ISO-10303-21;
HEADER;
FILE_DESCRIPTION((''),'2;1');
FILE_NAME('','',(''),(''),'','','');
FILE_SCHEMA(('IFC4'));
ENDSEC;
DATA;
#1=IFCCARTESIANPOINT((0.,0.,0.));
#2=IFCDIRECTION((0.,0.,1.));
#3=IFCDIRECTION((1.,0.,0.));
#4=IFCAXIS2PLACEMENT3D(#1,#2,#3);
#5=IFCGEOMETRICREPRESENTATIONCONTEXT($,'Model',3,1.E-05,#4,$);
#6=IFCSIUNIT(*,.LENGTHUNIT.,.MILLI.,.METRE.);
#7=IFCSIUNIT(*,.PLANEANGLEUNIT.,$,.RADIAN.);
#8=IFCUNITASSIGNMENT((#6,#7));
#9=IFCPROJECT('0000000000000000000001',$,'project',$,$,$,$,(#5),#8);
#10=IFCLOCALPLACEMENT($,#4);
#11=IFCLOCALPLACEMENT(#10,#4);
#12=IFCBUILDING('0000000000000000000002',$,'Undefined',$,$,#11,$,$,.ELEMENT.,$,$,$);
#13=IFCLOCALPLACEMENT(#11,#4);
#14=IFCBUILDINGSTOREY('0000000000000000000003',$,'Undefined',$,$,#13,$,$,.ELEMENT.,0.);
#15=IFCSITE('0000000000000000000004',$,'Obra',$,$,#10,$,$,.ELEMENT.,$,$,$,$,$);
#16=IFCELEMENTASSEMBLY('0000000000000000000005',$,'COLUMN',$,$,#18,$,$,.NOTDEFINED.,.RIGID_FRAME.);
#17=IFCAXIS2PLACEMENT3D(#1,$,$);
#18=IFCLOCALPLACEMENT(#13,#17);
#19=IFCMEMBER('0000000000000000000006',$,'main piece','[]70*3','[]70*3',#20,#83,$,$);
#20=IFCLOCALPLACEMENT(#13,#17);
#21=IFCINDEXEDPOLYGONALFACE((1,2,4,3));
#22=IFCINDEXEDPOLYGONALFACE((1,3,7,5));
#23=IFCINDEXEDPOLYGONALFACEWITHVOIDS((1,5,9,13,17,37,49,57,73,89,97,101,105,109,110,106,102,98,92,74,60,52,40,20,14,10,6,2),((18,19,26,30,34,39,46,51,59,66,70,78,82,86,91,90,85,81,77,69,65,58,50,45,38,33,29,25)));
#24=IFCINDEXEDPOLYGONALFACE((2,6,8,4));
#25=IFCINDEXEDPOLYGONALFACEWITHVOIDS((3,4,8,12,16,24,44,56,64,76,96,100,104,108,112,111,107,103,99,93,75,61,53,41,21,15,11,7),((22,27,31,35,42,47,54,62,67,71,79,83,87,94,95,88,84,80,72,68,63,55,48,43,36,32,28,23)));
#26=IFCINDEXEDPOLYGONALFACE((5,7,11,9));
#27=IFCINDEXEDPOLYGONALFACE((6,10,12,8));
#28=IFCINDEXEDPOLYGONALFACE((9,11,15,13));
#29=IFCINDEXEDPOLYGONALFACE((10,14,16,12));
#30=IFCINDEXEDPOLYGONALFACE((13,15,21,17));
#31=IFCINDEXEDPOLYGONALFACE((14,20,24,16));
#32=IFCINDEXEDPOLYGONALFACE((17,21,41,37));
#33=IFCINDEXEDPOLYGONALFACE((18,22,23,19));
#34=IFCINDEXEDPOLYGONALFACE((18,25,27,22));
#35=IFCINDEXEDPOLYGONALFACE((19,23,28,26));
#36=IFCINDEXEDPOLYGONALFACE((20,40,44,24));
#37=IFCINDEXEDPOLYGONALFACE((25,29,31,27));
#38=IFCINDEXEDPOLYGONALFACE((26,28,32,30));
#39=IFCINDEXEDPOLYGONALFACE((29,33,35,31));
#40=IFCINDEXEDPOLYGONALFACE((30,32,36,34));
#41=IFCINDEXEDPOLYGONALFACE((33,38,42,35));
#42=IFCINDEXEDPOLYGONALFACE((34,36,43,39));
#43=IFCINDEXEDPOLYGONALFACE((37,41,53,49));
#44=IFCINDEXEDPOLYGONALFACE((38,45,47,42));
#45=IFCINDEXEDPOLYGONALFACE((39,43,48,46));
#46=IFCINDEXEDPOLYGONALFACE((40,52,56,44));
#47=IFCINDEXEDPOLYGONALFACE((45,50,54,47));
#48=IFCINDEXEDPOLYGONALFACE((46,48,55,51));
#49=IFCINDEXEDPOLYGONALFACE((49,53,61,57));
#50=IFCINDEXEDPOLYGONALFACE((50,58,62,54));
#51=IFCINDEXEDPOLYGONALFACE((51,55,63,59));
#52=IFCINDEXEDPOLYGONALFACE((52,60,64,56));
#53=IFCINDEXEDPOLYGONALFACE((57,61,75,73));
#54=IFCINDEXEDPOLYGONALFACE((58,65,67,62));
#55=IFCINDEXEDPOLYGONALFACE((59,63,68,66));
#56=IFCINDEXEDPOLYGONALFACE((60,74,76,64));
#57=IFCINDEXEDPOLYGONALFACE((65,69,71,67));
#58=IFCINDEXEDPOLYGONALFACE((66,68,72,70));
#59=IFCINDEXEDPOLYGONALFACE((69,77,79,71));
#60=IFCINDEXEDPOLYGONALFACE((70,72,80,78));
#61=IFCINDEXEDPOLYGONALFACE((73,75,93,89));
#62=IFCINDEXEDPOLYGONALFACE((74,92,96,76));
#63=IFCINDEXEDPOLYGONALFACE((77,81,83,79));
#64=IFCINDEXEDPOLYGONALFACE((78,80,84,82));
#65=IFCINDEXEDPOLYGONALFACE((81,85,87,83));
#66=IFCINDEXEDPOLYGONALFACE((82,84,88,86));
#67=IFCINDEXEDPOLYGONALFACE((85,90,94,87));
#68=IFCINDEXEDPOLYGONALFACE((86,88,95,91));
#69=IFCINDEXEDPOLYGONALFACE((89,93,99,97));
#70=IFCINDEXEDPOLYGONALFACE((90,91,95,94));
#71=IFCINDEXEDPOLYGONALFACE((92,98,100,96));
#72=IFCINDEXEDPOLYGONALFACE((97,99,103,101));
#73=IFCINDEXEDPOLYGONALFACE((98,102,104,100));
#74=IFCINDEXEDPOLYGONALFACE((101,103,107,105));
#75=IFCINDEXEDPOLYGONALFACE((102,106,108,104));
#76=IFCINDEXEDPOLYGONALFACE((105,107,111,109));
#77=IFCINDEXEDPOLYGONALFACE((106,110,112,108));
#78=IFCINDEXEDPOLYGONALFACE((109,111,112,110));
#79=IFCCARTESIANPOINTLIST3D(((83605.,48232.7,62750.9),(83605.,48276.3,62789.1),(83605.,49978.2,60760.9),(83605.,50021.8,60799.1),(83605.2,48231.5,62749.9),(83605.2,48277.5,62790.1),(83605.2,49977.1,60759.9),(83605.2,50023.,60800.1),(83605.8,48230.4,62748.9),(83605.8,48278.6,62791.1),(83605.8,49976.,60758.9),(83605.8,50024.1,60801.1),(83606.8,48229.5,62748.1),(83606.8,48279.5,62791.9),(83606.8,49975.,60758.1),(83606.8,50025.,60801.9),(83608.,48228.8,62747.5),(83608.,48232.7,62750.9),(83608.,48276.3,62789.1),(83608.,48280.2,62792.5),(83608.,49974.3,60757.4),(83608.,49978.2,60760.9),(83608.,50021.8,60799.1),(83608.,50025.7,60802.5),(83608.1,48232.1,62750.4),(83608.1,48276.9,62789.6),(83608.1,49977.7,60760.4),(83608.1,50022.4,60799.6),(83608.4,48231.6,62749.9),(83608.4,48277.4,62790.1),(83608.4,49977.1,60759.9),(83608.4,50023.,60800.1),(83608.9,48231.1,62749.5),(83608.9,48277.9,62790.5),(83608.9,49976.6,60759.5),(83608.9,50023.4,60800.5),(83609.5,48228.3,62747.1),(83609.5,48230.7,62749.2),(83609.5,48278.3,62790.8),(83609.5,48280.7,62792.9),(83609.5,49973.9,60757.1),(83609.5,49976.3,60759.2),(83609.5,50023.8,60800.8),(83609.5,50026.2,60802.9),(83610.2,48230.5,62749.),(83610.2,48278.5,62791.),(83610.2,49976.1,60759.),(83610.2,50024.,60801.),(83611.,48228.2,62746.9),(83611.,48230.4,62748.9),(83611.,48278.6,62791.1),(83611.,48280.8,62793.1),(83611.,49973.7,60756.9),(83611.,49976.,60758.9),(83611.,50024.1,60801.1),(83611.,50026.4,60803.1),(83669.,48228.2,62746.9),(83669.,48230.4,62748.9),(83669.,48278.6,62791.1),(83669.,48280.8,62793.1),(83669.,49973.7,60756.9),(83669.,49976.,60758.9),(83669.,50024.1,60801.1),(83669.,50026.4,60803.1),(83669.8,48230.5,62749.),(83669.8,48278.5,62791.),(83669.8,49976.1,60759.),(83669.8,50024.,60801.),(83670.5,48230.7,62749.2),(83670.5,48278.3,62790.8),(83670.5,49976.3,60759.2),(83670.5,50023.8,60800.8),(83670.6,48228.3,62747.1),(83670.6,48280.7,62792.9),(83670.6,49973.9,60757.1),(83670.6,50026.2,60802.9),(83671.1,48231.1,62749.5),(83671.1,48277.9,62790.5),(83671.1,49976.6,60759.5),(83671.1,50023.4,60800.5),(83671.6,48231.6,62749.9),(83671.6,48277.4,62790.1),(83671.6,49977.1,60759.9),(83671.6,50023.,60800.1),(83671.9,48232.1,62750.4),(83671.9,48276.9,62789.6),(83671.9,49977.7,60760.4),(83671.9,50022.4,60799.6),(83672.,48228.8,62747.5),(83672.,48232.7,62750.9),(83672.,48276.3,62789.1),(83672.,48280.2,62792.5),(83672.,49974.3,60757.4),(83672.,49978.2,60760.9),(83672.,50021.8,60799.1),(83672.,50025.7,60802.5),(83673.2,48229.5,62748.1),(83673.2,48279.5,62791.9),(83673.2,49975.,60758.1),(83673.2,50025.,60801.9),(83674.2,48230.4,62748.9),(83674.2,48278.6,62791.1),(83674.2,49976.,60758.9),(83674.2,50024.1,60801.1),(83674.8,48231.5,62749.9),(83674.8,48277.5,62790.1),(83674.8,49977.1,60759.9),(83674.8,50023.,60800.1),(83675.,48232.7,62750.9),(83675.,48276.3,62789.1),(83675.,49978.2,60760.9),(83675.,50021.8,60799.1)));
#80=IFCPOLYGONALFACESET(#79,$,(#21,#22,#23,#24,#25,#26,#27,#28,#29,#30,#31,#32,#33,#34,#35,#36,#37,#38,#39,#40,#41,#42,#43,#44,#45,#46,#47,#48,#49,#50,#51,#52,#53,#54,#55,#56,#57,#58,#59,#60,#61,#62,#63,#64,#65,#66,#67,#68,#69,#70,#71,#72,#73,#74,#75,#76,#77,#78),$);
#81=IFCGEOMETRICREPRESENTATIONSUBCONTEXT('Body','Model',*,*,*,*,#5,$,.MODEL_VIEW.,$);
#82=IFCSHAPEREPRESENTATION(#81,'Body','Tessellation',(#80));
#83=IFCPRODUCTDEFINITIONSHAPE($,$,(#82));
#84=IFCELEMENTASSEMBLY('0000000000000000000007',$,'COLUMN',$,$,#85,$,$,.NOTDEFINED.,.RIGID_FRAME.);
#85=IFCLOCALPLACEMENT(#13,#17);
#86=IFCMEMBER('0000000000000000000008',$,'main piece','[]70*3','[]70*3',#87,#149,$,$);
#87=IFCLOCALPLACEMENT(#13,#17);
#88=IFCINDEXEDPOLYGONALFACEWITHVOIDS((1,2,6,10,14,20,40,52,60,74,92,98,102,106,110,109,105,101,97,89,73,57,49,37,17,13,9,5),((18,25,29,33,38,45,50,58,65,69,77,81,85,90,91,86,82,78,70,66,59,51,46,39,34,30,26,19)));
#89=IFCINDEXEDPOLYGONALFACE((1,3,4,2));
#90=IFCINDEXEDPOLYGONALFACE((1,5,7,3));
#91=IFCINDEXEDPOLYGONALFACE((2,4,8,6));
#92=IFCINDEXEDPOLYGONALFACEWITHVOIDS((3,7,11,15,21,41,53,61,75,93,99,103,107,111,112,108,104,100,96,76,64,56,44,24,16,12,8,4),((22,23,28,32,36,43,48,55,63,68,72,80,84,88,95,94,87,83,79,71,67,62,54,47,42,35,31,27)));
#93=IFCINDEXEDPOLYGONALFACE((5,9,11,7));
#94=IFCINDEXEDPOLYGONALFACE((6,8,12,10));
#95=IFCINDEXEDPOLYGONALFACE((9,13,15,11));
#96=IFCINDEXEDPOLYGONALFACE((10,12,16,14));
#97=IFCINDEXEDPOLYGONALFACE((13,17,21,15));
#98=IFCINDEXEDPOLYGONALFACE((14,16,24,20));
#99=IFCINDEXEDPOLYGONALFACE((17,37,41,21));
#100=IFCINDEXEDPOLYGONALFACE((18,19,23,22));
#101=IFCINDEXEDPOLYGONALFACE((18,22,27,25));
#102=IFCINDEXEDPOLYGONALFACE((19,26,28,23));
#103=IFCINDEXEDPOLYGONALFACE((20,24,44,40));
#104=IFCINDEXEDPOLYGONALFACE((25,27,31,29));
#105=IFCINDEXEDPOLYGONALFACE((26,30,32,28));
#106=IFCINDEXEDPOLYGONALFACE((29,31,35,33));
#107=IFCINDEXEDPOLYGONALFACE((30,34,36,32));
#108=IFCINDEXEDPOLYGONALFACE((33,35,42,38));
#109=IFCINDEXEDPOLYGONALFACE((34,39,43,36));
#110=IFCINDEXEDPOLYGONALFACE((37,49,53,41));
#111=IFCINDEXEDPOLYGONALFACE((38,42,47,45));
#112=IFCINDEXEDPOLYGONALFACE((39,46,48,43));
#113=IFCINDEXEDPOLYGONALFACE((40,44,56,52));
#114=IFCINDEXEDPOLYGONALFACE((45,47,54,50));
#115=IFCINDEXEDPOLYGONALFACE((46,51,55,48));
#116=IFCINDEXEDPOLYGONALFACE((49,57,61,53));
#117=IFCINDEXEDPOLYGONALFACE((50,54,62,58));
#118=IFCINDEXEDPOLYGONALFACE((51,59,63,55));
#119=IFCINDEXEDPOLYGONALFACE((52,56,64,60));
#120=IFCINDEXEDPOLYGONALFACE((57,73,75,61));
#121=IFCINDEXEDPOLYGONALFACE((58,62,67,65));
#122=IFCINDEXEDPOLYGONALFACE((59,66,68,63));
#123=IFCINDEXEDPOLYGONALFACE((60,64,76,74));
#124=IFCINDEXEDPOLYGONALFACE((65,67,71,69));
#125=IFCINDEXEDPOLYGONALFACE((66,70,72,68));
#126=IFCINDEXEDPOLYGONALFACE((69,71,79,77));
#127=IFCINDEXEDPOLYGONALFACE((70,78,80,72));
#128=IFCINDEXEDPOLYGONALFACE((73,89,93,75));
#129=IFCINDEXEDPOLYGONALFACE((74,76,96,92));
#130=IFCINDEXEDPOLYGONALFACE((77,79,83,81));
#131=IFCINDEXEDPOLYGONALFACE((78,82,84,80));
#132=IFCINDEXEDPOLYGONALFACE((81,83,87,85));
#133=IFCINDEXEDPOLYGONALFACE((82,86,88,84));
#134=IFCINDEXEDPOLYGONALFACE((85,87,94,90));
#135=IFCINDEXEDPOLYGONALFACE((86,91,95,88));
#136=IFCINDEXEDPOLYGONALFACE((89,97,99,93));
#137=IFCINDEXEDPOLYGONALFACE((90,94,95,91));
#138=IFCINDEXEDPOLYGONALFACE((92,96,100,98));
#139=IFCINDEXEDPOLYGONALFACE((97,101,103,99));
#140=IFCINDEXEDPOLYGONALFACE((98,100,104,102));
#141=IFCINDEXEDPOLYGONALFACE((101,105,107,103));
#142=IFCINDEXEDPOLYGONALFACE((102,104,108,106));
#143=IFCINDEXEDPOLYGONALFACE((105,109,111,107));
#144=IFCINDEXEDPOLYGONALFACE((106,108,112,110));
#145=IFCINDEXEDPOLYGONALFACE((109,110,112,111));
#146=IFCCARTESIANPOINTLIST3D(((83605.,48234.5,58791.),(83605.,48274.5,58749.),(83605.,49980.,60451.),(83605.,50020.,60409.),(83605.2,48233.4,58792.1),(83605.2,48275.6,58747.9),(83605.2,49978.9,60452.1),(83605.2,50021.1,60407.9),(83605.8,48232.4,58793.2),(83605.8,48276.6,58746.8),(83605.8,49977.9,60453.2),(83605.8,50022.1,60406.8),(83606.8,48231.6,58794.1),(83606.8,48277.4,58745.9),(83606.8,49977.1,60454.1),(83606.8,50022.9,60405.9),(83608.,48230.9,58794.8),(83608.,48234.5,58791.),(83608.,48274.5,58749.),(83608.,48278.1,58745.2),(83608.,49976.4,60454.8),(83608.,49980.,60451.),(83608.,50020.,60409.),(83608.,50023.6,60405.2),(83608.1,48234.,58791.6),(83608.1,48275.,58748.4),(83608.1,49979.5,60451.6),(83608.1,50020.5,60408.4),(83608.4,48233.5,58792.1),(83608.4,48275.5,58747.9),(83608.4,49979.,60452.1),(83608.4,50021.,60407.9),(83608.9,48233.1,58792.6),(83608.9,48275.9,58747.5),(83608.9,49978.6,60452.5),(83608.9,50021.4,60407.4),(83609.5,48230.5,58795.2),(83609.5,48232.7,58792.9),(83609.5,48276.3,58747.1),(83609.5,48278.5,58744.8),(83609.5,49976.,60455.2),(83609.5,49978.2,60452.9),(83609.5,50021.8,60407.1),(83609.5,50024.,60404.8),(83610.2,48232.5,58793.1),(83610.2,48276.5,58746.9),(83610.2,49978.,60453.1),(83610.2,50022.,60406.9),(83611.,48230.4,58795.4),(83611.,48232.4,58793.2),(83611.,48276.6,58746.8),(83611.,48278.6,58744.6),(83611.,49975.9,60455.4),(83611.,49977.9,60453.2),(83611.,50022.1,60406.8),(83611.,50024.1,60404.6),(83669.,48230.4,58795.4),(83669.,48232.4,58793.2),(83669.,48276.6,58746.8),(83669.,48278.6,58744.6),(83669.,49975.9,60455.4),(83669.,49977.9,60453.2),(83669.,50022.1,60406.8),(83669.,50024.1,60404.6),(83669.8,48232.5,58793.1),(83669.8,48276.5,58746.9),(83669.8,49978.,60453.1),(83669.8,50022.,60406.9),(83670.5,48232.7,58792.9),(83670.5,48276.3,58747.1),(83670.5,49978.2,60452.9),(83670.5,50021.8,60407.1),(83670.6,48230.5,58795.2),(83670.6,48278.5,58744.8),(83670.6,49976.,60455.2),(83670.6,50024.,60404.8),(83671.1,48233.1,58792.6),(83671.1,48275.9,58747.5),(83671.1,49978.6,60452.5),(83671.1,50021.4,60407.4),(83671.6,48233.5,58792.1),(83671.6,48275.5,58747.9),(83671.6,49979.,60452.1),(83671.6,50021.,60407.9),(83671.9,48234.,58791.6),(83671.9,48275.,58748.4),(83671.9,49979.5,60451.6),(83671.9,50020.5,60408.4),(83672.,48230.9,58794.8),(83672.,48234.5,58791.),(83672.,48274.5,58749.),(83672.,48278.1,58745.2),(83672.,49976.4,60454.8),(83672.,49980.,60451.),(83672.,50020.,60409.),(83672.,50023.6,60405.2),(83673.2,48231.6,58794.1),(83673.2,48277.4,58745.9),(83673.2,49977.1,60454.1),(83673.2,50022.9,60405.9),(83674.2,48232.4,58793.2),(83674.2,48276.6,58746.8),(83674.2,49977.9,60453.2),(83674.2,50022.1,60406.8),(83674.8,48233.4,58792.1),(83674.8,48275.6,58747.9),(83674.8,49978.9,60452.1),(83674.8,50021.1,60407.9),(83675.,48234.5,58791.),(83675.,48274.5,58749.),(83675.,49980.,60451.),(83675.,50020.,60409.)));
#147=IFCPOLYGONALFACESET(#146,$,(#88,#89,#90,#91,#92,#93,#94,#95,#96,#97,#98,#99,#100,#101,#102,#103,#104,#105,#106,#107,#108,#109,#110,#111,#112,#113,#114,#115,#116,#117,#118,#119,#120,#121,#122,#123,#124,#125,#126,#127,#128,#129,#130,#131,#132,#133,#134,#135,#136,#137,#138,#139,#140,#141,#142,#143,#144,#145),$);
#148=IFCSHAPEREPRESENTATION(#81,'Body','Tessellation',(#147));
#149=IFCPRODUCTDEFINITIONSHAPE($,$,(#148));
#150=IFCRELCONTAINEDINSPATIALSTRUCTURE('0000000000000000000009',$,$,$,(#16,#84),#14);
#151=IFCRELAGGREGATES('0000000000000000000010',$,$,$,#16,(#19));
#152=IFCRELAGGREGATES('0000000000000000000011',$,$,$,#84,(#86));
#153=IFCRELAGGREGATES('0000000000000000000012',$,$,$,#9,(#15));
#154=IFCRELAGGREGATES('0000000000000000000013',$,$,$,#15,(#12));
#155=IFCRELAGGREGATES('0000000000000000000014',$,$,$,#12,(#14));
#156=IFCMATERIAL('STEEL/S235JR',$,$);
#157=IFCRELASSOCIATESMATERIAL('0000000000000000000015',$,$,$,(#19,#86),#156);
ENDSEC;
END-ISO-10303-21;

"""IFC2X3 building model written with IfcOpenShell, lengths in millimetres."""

from ifc_helpers import new_model, si_unit, frame, origin_with_axes, origin_2d_with_axis, place, context, subcontext, project, spatial, hollow_rectangle, extrude, material, element, aggregate, save


model = new_model("IFC2X3")

# Units and contexts
model_context = context("Model", 3, precision=1e-05, world=origin_with_axes())
body_context = subcontext(model_context, "Body", "Model", "MODEL_VIEW")
ifc_project = project(units=[si_unit("LENGTHUNIT", "METRE", prefix="MILLI"), si_unit("PLANEANGLEUNIT", "RADIAN")], contexts=[model_context])

# Site, building, storey
site_placement = place(None, origin_with_axes())
site = spatial("IfcSite", under=ifc_project, at=site_placement, Name="Obra", CompositionType="ELEMENT")
building_placement = place(site_placement, origin_with_axes())
building = spatial("IfcBuilding", under=site, at=building_placement, Name="Undefined", CompositionType="ELEMENT")
storey_placement = place(building_placement, origin_with_axes())
storey = spatial("IfcBuildingStorey", under=building, at=storey_placement, Name="Undefined", CompositionType="ELEMENT", Elevation=0.0)

# Shared definitions
ifc_material = material(Name="STEEL/S235JR")

# Element assemblies, members
assembly_1_placement = place(storey_placement, origin_with_axes())
assembly_1 = element("IfcElementAssembly", 1, at=assembly_1_placement, inside=storey, Name="COLUMN", AssemblyPlace="NOTDEFINED", PredefinedType="RIGID_FRAME")
member_1_placement = place(assembly_1_placement, frame((83640.0, 50000.0, 60780.0), z_axis=(1.0, 0.0, 0.0), x_axis=(0.0, -0.659423, 0.751772)))
member_1 = element("IfcMember", 2, at=member_1_placement, material=ifc_material, Name="main piece", Description="[]70*3", ObjectType="[]70*3", context=body_context, shape_type="SweptSolid", body=[
    extrude(hollow_rectangle(XDim=70.0, YDim=70.0, WallThickness=3.0, InnerFilletRadius=3.0, OuterFilletRadius=6.0, at=origin_2d_with_axis()), frame((2647.1, 0.0, 0.0), z_axis=(-1.0, 0.0, 0.0), x_axis=(0.0, -1.0, 0.0)), (0.0, 0.0, 1.0), 2647.1),
])
aggregate(assembly_1, [member_1])
assembly_2_placement = place(storey_placement, origin_with_axes())
assembly_2 = element("IfcElementAssembly", 3, at=assembly_2_placement, inside=storey, Name="COLUMN", AssemblyPlace="NOTDEFINED", PredefinedType="RIGID_FRAME")
member_2_placement = place(assembly_2_placement, frame((83640.0, 48254.5, 58770.0), z_axis=(-1.0, 0.0, 0.0), x_axis=(0.0, 0.724633, 0.689135)))
member_2 = element("IfcMember", 4, at=member_2_placement, material=ifc_material, Name="main piece", Description="[]70*3", ObjectType="[]70*3", context=body_context, shape_type="SweptSolid", body=[
    extrude(hollow_rectangle(XDim=70.0, YDim=70.0, WallThickness=3.0, InnerFilletRadius=3.0, OuterFilletRadius=6.0, at=origin_2d_with_axis()), frame((2408.8, 0.0, 0.0), z_axis=(-1.0, 0.0, 0.0), x_axis=(0.0, -1.0, 0.0)), (0.0, 0.0, 1.0), 2408.8),
])
aggregate(assembly_2, [member_2])

save(model, "model.ifc")
